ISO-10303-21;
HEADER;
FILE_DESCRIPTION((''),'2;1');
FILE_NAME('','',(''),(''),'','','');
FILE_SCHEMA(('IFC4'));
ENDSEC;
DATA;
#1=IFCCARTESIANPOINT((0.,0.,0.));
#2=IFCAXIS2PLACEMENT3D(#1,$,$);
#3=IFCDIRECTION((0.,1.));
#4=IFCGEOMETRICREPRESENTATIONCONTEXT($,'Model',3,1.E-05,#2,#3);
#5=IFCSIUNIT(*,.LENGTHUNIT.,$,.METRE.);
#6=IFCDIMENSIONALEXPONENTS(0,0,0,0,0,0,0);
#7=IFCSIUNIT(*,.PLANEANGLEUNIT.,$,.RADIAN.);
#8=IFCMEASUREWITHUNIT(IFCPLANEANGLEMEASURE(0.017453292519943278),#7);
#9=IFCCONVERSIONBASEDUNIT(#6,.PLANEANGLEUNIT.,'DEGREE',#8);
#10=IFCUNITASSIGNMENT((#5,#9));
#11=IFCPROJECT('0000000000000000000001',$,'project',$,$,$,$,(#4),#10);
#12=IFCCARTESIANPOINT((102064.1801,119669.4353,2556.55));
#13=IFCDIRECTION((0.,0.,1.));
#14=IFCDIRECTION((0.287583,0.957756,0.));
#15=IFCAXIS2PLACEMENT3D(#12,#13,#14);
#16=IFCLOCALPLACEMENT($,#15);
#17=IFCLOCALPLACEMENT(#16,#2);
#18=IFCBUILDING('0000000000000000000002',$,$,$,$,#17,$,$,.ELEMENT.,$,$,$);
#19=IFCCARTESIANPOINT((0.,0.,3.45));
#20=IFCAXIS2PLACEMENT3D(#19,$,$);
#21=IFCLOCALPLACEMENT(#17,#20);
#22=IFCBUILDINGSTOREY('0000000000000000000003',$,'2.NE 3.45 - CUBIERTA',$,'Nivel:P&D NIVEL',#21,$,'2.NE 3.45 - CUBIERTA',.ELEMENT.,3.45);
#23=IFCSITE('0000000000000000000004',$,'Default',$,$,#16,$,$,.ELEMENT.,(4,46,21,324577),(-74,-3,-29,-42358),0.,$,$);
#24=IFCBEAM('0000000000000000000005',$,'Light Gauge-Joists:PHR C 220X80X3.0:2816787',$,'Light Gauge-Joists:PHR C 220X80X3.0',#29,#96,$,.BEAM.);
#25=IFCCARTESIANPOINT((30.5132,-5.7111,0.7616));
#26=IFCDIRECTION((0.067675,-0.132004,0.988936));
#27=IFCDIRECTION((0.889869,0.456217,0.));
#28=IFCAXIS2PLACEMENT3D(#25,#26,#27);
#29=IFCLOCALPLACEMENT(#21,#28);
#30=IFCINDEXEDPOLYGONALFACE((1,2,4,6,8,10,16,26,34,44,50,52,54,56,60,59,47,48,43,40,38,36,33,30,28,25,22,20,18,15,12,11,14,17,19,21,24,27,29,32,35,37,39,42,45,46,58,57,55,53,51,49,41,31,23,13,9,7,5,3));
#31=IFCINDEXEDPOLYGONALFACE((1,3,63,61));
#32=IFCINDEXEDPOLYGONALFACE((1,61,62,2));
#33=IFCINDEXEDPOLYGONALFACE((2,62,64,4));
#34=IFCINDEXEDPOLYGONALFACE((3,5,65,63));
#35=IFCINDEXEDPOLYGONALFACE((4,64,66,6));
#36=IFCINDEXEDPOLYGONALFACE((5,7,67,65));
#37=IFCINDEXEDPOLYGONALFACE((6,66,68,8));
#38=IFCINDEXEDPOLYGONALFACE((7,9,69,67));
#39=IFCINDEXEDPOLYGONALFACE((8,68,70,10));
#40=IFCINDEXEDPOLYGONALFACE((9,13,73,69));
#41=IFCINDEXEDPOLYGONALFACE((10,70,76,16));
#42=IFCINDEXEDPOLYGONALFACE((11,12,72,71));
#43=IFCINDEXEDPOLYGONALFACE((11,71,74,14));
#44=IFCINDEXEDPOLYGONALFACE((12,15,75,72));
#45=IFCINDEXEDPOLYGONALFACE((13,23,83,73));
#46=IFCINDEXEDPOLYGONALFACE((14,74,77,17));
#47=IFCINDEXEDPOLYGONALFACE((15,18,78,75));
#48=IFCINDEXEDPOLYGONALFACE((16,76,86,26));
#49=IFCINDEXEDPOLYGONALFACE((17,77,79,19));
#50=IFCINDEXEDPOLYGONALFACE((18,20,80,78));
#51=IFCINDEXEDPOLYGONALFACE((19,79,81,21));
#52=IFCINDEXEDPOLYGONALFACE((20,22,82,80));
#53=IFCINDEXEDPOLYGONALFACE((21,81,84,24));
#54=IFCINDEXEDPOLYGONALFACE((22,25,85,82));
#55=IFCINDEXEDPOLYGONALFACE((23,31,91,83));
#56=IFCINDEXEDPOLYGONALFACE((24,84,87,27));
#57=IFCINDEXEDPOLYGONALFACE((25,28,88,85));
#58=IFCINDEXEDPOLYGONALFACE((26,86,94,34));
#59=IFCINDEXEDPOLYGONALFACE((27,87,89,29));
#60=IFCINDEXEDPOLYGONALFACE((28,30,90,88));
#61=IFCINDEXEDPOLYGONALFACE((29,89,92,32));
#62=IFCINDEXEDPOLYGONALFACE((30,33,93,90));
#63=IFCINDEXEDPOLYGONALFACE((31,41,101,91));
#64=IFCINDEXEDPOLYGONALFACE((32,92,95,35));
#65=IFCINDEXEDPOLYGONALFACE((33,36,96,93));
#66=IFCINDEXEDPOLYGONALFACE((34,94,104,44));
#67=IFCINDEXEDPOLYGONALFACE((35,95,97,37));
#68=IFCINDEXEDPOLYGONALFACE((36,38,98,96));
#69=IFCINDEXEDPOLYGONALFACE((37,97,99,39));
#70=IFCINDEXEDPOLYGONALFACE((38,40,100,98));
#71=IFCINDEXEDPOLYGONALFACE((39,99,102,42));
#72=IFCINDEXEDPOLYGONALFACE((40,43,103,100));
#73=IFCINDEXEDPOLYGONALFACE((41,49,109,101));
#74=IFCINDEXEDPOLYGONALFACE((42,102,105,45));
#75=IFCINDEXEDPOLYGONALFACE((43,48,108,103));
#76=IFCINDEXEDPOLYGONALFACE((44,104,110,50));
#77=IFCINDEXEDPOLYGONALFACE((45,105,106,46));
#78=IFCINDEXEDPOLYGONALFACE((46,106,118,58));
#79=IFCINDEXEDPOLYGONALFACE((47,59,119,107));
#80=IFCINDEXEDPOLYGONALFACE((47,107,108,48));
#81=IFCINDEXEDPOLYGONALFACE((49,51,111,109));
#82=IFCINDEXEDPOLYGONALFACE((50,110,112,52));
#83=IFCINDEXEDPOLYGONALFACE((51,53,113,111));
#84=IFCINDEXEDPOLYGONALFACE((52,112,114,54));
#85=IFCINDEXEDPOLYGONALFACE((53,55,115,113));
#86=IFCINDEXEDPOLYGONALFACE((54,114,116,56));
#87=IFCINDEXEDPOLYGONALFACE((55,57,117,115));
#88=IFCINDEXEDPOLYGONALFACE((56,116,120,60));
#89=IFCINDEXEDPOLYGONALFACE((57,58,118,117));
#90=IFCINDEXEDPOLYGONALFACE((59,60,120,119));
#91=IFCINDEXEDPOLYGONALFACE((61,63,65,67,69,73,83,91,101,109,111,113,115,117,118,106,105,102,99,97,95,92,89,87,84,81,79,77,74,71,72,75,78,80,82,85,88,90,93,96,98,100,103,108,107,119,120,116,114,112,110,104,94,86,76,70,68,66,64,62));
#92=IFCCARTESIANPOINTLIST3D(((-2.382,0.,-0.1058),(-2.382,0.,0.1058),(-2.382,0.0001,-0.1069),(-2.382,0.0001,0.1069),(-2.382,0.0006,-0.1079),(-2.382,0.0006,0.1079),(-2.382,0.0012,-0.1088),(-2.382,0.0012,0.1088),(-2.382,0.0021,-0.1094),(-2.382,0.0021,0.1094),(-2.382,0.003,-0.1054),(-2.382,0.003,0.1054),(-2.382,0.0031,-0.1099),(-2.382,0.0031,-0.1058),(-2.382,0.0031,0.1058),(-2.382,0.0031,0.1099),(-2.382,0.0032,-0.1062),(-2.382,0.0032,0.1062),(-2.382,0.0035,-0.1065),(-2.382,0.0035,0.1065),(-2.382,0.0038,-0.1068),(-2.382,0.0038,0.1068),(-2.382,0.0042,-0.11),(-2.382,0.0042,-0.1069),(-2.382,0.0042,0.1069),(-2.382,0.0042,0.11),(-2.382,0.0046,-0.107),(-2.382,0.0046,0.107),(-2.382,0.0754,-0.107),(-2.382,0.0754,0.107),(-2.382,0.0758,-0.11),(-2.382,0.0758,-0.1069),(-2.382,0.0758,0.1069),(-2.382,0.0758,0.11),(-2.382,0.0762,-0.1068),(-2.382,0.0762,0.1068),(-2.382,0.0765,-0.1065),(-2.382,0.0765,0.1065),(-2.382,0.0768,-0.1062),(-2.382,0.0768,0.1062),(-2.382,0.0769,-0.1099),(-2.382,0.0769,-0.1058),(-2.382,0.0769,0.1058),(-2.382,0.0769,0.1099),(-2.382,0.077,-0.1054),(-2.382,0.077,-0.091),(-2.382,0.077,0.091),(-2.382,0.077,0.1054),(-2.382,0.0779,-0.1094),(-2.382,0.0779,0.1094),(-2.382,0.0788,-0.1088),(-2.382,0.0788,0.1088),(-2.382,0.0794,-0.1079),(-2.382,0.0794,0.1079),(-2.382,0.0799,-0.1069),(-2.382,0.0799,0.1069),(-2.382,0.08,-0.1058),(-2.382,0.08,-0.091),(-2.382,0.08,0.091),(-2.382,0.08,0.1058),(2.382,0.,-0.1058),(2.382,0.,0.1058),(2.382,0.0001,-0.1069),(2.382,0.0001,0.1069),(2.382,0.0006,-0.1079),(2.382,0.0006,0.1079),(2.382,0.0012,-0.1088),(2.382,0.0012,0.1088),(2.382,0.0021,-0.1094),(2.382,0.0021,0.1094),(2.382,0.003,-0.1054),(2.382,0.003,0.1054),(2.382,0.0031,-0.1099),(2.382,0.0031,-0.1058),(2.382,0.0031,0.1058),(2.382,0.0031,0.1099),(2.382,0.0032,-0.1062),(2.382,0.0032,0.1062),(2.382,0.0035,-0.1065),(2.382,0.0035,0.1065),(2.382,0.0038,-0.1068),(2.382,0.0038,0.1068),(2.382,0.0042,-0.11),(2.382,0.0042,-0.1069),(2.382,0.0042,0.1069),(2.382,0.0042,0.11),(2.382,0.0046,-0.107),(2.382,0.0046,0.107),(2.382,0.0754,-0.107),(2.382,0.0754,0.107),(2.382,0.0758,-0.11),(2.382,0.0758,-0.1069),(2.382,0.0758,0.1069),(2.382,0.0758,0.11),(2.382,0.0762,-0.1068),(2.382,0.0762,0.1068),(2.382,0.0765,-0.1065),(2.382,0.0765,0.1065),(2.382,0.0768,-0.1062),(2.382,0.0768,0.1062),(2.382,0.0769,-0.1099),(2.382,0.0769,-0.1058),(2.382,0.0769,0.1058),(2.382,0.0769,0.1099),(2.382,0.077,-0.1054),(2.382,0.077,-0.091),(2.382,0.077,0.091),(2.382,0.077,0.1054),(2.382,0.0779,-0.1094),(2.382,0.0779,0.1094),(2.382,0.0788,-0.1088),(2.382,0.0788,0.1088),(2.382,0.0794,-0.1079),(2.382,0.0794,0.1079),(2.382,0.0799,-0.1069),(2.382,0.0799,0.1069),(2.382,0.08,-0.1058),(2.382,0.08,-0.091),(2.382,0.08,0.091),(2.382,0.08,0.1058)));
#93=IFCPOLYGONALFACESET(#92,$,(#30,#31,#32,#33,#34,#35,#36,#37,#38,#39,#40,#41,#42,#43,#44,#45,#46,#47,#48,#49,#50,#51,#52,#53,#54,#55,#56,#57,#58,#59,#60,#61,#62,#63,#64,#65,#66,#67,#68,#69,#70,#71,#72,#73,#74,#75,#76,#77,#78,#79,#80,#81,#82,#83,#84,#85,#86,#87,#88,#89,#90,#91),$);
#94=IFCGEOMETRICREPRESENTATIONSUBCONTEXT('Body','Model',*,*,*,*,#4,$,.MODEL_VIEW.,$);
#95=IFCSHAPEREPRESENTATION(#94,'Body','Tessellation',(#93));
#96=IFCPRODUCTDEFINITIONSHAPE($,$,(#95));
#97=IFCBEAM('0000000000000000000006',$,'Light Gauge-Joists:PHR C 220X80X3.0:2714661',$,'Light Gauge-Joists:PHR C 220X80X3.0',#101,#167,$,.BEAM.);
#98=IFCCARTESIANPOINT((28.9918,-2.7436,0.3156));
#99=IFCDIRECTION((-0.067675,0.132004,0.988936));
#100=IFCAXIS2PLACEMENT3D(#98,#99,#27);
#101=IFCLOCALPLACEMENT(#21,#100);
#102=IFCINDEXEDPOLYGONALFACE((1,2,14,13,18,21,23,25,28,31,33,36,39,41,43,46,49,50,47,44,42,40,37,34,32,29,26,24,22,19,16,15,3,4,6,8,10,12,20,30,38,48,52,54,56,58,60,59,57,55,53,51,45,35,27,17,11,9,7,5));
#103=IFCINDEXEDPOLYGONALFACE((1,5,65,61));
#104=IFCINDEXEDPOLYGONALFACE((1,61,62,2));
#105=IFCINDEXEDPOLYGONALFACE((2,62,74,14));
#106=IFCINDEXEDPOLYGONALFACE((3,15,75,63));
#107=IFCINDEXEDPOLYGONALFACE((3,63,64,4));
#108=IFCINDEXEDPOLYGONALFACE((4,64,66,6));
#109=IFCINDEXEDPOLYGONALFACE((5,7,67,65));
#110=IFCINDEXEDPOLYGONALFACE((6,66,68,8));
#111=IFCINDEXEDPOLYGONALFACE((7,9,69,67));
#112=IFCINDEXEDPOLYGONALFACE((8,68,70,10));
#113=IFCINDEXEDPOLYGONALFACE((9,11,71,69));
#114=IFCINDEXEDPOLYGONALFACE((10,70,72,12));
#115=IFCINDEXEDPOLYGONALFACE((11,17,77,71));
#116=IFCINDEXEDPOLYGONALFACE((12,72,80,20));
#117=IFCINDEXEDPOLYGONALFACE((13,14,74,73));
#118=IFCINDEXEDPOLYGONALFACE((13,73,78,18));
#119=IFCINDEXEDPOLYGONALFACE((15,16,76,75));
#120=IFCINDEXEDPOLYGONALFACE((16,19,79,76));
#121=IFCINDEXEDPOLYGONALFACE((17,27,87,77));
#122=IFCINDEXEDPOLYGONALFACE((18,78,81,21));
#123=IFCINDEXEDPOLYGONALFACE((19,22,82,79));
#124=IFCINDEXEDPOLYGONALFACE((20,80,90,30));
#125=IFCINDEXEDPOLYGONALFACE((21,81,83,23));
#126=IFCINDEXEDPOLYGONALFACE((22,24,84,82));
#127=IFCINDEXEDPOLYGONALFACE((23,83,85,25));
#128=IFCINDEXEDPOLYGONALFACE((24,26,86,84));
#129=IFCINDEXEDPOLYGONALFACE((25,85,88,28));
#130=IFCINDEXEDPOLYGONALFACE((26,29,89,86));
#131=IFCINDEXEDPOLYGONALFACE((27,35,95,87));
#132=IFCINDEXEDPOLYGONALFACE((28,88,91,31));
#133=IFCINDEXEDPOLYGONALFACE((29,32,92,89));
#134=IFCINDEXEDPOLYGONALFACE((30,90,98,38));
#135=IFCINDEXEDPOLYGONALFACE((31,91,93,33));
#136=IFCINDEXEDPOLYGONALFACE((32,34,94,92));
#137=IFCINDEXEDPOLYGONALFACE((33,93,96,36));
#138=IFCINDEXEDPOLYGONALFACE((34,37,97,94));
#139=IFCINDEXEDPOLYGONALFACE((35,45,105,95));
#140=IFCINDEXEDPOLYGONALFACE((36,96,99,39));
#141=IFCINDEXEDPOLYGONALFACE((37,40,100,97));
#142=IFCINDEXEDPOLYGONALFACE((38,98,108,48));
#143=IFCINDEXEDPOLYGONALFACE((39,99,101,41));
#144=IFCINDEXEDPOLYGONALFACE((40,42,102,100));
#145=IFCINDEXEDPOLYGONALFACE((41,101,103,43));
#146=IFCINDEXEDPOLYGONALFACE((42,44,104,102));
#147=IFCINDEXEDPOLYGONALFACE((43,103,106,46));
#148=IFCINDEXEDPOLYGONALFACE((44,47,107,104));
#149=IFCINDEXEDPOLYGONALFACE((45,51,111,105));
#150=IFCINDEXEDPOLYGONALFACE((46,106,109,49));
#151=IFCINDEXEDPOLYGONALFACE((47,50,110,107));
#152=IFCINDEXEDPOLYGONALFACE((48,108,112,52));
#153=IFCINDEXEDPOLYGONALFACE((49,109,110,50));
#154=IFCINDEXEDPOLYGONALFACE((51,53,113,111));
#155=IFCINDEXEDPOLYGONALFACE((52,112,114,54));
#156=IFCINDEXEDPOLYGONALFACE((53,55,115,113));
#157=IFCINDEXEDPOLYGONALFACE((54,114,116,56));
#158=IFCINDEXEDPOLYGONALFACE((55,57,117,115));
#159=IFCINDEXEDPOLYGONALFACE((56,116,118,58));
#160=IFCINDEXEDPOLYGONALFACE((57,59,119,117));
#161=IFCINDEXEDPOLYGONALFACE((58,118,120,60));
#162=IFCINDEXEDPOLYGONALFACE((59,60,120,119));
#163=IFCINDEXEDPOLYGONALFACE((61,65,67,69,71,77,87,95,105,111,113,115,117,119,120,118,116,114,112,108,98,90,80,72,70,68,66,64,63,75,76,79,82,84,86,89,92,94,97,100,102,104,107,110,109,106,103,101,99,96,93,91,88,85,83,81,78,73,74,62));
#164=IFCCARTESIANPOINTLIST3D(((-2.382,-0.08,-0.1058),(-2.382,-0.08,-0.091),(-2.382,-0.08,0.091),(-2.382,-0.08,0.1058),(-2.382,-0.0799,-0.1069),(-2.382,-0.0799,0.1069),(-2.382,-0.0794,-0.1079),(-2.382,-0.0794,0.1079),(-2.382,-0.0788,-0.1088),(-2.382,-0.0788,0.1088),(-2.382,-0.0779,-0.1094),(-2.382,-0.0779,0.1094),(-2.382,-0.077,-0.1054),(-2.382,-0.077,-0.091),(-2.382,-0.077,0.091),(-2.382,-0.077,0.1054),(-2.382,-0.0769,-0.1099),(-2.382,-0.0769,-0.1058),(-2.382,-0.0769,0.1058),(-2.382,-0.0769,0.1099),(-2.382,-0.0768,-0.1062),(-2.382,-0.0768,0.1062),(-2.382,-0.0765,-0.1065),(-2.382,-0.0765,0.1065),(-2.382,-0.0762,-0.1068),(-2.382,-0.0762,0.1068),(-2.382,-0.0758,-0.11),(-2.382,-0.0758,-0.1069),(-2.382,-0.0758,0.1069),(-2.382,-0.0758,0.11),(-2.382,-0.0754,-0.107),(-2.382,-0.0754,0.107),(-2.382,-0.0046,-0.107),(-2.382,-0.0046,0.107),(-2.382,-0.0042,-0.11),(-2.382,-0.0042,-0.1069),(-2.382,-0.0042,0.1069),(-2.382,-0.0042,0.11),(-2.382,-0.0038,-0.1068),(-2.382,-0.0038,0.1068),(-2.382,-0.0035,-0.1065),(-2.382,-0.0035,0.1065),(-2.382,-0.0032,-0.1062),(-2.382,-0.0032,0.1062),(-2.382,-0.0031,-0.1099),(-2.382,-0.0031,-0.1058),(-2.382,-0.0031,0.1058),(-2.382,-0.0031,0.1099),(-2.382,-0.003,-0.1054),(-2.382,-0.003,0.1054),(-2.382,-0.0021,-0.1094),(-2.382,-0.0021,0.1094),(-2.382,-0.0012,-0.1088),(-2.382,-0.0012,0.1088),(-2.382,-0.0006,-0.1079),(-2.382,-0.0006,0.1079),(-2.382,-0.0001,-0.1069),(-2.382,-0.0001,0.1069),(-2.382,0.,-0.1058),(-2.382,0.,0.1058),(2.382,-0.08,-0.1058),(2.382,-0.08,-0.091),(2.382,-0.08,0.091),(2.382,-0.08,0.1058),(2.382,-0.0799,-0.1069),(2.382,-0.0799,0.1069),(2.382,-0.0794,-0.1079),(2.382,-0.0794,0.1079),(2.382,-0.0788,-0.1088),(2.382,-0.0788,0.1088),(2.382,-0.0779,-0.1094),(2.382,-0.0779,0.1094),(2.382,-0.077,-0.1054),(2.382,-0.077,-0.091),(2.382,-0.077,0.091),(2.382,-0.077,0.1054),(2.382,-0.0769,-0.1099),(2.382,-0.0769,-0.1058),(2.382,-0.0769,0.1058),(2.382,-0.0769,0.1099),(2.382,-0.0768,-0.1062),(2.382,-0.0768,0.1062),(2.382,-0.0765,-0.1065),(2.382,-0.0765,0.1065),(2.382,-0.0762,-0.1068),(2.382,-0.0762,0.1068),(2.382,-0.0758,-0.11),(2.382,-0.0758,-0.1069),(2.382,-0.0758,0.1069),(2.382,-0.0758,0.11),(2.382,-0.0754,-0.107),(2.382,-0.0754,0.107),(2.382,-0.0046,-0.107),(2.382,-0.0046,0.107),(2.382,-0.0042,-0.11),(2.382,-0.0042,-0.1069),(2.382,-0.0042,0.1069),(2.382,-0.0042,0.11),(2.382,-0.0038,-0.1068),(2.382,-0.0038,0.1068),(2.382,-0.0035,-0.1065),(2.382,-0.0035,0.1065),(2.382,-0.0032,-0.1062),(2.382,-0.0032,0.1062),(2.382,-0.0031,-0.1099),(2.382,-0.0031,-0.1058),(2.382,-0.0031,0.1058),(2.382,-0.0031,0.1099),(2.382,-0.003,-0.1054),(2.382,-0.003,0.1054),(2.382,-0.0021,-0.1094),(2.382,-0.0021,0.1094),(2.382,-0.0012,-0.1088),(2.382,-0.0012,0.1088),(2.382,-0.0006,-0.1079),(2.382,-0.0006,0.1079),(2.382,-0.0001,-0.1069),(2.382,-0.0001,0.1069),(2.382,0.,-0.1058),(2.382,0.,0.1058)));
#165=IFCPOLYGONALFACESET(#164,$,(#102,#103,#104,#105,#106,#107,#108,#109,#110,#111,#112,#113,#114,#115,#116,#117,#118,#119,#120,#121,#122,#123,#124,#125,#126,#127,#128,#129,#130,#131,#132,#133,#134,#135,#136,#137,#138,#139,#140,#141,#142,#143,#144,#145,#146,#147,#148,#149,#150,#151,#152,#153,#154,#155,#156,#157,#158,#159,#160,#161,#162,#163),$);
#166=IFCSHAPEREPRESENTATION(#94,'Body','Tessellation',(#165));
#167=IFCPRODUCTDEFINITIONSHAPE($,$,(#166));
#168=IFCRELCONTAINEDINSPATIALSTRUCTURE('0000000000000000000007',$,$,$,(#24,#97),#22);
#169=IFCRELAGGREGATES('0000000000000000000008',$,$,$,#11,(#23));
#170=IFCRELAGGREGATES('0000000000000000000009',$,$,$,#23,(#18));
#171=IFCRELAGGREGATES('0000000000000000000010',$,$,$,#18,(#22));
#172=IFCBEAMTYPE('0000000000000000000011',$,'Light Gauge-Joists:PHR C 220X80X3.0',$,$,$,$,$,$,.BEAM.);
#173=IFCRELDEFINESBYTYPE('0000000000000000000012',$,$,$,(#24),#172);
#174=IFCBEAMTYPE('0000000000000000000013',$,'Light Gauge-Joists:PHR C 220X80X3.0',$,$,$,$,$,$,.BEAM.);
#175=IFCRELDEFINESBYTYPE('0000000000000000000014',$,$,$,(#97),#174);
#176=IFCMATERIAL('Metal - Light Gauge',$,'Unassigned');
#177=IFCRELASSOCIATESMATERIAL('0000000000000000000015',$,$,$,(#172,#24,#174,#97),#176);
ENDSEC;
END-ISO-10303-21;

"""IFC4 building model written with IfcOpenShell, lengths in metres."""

from ifc_helpers import new_model, entity, si_unit, converted_unit, direction, frame, origin, place, context, subcontext, project, spatial, line, arc, indexed_curve, outline, extrude, source, transform, mapped, material, type_object, type_shapes, element, save


model = new_model("IFC4")

# Units and contexts
model_context = context("Model", 3, precision=1e-05, world=origin(), true_north=direction((0.0, 1.0)))
body_context = subcontext(model_context, "Body", "Model", "MODEL_VIEW")
ifc_project = project(units=[si_unit("LENGTHUNIT", "METRE"), converted_unit("PLANEANGLEUNIT", "DEGREE", entity("IfcPlaneAngleMeasure", 0.017453292519943278), si_unit("PLANEANGLEUNIT", "RADIAN"), dimensions=[0, 0, 0, 0, 0, 0, 0])], contexts=[model_context])

# Site, building, storey
site_placement = place(None, frame((102064.1801, 119669.4353, 2556.55), z_axis=(0.0, 0.0, 1.0), x_axis=(0.287583, 0.957756, 0.0)))
site = spatial("IfcSite", under=ifc_project, at=site_placement, Name="Default", CompositionType="ELEMENT", RefLatitude=(4, 46, 21, 324577), RefLongitude=(-74, -3, -29, -42358), RefElevation=0.0)
building_placement = place(site_placement, origin())
building = spatial("IfcBuilding", under=site, at=building_placement, CompositionType="ELEMENT")
storey_placement = place(building_placement, frame((0.0, 0.0, 3.45)))
storey = spatial("IfcBuildingStorey", under=building, at=storey_placement, Name="2.NE 3.45 - CUBIERTA", ObjectType="Nivel:P&D NIVEL", LongName="2.NE 3.45 - CUBIERTA", CompositionType="ELEMENT", Elevation=3.45)

# Beams
ifc_material_1 = material(Name="Metal - Light Gauge", Category="Unassigned")
beam_type_1 = type_object("IfcBeamType", Name="Light Gauge-Joists:PHR C 220X80X3.0", PredefinedType="BEAM", material=ifc_material_1)
shared_shape_1 = source(origin(), body_context, "Body", "SweptSolid", [
    extrude(outline(indexed_curve([(-0.0477, -0.1058), (-0.0465, -0.1088), (-0.0435, -0.11), (0.0281, -0.11), (0.0311, -0.1088), (0.0323, -0.1058), (0.0323, -0.091), (0.0293, -0.091), (0.0293, -0.1054), (0.0288, -0.1065), (0.0277, -0.107), (-0.0431, -0.107), (-0.0442, -0.1065), (-0.0447, -0.1054), (-0.0447, 0.1054), (-0.0442, 0.1065), (-0.0431, 0.107), (0.0277, 0.107), (0.0288, 0.1065), (0.0293, 0.1054), (0.0293, 0.091), (0.0323, 0.091), (0.0323, 0.1058), (0.0311, 0.1088), (0.0281, 0.11), (-0.0435, 0.11), (-0.0465, 0.1088), (-0.0477, 0.1058)], segments=[arc(1, 2, 3), line(3, 4), arc(4, 5, 6), line(6, 7, 8, 9), arc(9, 10, 11), line(11, 12), arc(12, 13, 14), line(14, 15), arc(15, 16, 17), line(17, 18), arc(18, 19, 20), line(20, 21, 22, 23), arc(23, 24, 25), line(25, 26), arc(26, 27, 28), line(28, 1)], self_intersect=False)), frame((-2.382, 0.0477, 0.0), z_axis=(1.0, 0.0, 0.0), x_axis=(0.0, 1.0, 0.0)), (0.0, 0.0, 1.0), 4.764),
])
type_shapes(beam_type_1, [shared_shape_1])
for number, where, z_axis, x_axis, name in (
    (1, (30.5132, -5.7111, 0.7616), (0.067675, -0.132004, 0.988936), (0.889869, 0.456217, 0.0), "Light Gauge-Joists:PHR C 220X80X3.0:2816787"),
):
    element("IfcBeam", number, at=place(storey_placement, frame(where, z_axis=z_axis, x_axis=x_axis)), inside=storey, type_object=beam_type_1, material=ifc_material_1, Name=name, ObjectType="Light Gauge-Joists:PHR C 220X80X3.0", PredefinedType="BEAM", context=body_context, shape_type="MappedRepresentation", body=[
        mapped(shared_shape_1, transform((0.0, 0.0, 0.0), scale=1.0)),
    ])
beam_type_2 = type_object("IfcBeamType", Name="Light Gauge-Joists:PHR C 220X80X3.0", PredefinedType="BEAM", material=ifc_material_1)
shared_shape_2 = source(origin(), body_context, "Body", "SweptSolid", [
    extrude(outline(indexed_curve([(-0.1058, -0.0477), (0.1058, -0.0477), (0.1088, -0.0465), (0.11, -0.0435), (0.11, 0.0281), (0.1088, 0.0311), (0.1058, 0.0323), (0.091, 0.0323), (0.091, 0.0293), (0.1054, 0.0293), (0.1065, 0.0288), (0.107, 0.0277), (0.107, -0.0431), (0.1065, -0.0442), (0.1054, -0.0447), (-0.1054, -0.0447), (-0.1065, -0.0442), (-0.107, -0.0431), (-0.107, 0.0277), (-0.1065, 0.0288), (-0.1054, 0.0293), (-0.091, 0.0293), (-0.091, 0.0323), (-0.1058, 0.0323), (-0.1088, 0.0311), (-0.11, 0.0281), (-0.11, -0.0435), (-0.1088, -0.0465)], segments=[line(1, 2), arc(2, 3, 4), line(4, 5), arc(5, 6, 7), line(7, 8, 9, 10), arc(10, 11, 12), line(12, 13), arc(13, 14, 15), line(15, 16), arc(16, 17, 18), line(18, 19), arc(19, 20, 21), line(21, 22, 23, 24), arc(24, 25, 26), line(26, 27), arc(27, 28, 1)], self_intersect=False)), frame((-2.382, -0.0477, 0.0), z_axis=(1.0, 0.0, 0.0), x_axis=(0.0, 0.0, 1.0)), (0.0, 0.0, 1.0), 4.764),
])
type_shapes(beam_type_2, [shared_shape_2])
for number, where, z_axis, x_axis, name in (
    (2, (28.9918, -2.7436, 0.3156), (-0.067675, 0.132004, 0.988936), (0.889869, 0.456217, 0.0), "Light Gauge-Joists:PHR C 220X80X3.0:2714661"),
):
    element("IfcBeam", number, at=place(storey_placement, frame(where, z_axis=z_axis, x_axis=x_axis)), inside=storey, type_object=beam_type_2, material=ifc_material_1, Name=name, ObjectType="Light Gauge-Joists:PHR C 220X80X3.0", PredefinedType="BEAM", context=body_context, shape_type="MappedRepresentation", body=[
        mapped(shared_shape_2, transform((0.0, 0.0, 0.0), scale=1.0)),
    ])

save(model, "model.ifc")
